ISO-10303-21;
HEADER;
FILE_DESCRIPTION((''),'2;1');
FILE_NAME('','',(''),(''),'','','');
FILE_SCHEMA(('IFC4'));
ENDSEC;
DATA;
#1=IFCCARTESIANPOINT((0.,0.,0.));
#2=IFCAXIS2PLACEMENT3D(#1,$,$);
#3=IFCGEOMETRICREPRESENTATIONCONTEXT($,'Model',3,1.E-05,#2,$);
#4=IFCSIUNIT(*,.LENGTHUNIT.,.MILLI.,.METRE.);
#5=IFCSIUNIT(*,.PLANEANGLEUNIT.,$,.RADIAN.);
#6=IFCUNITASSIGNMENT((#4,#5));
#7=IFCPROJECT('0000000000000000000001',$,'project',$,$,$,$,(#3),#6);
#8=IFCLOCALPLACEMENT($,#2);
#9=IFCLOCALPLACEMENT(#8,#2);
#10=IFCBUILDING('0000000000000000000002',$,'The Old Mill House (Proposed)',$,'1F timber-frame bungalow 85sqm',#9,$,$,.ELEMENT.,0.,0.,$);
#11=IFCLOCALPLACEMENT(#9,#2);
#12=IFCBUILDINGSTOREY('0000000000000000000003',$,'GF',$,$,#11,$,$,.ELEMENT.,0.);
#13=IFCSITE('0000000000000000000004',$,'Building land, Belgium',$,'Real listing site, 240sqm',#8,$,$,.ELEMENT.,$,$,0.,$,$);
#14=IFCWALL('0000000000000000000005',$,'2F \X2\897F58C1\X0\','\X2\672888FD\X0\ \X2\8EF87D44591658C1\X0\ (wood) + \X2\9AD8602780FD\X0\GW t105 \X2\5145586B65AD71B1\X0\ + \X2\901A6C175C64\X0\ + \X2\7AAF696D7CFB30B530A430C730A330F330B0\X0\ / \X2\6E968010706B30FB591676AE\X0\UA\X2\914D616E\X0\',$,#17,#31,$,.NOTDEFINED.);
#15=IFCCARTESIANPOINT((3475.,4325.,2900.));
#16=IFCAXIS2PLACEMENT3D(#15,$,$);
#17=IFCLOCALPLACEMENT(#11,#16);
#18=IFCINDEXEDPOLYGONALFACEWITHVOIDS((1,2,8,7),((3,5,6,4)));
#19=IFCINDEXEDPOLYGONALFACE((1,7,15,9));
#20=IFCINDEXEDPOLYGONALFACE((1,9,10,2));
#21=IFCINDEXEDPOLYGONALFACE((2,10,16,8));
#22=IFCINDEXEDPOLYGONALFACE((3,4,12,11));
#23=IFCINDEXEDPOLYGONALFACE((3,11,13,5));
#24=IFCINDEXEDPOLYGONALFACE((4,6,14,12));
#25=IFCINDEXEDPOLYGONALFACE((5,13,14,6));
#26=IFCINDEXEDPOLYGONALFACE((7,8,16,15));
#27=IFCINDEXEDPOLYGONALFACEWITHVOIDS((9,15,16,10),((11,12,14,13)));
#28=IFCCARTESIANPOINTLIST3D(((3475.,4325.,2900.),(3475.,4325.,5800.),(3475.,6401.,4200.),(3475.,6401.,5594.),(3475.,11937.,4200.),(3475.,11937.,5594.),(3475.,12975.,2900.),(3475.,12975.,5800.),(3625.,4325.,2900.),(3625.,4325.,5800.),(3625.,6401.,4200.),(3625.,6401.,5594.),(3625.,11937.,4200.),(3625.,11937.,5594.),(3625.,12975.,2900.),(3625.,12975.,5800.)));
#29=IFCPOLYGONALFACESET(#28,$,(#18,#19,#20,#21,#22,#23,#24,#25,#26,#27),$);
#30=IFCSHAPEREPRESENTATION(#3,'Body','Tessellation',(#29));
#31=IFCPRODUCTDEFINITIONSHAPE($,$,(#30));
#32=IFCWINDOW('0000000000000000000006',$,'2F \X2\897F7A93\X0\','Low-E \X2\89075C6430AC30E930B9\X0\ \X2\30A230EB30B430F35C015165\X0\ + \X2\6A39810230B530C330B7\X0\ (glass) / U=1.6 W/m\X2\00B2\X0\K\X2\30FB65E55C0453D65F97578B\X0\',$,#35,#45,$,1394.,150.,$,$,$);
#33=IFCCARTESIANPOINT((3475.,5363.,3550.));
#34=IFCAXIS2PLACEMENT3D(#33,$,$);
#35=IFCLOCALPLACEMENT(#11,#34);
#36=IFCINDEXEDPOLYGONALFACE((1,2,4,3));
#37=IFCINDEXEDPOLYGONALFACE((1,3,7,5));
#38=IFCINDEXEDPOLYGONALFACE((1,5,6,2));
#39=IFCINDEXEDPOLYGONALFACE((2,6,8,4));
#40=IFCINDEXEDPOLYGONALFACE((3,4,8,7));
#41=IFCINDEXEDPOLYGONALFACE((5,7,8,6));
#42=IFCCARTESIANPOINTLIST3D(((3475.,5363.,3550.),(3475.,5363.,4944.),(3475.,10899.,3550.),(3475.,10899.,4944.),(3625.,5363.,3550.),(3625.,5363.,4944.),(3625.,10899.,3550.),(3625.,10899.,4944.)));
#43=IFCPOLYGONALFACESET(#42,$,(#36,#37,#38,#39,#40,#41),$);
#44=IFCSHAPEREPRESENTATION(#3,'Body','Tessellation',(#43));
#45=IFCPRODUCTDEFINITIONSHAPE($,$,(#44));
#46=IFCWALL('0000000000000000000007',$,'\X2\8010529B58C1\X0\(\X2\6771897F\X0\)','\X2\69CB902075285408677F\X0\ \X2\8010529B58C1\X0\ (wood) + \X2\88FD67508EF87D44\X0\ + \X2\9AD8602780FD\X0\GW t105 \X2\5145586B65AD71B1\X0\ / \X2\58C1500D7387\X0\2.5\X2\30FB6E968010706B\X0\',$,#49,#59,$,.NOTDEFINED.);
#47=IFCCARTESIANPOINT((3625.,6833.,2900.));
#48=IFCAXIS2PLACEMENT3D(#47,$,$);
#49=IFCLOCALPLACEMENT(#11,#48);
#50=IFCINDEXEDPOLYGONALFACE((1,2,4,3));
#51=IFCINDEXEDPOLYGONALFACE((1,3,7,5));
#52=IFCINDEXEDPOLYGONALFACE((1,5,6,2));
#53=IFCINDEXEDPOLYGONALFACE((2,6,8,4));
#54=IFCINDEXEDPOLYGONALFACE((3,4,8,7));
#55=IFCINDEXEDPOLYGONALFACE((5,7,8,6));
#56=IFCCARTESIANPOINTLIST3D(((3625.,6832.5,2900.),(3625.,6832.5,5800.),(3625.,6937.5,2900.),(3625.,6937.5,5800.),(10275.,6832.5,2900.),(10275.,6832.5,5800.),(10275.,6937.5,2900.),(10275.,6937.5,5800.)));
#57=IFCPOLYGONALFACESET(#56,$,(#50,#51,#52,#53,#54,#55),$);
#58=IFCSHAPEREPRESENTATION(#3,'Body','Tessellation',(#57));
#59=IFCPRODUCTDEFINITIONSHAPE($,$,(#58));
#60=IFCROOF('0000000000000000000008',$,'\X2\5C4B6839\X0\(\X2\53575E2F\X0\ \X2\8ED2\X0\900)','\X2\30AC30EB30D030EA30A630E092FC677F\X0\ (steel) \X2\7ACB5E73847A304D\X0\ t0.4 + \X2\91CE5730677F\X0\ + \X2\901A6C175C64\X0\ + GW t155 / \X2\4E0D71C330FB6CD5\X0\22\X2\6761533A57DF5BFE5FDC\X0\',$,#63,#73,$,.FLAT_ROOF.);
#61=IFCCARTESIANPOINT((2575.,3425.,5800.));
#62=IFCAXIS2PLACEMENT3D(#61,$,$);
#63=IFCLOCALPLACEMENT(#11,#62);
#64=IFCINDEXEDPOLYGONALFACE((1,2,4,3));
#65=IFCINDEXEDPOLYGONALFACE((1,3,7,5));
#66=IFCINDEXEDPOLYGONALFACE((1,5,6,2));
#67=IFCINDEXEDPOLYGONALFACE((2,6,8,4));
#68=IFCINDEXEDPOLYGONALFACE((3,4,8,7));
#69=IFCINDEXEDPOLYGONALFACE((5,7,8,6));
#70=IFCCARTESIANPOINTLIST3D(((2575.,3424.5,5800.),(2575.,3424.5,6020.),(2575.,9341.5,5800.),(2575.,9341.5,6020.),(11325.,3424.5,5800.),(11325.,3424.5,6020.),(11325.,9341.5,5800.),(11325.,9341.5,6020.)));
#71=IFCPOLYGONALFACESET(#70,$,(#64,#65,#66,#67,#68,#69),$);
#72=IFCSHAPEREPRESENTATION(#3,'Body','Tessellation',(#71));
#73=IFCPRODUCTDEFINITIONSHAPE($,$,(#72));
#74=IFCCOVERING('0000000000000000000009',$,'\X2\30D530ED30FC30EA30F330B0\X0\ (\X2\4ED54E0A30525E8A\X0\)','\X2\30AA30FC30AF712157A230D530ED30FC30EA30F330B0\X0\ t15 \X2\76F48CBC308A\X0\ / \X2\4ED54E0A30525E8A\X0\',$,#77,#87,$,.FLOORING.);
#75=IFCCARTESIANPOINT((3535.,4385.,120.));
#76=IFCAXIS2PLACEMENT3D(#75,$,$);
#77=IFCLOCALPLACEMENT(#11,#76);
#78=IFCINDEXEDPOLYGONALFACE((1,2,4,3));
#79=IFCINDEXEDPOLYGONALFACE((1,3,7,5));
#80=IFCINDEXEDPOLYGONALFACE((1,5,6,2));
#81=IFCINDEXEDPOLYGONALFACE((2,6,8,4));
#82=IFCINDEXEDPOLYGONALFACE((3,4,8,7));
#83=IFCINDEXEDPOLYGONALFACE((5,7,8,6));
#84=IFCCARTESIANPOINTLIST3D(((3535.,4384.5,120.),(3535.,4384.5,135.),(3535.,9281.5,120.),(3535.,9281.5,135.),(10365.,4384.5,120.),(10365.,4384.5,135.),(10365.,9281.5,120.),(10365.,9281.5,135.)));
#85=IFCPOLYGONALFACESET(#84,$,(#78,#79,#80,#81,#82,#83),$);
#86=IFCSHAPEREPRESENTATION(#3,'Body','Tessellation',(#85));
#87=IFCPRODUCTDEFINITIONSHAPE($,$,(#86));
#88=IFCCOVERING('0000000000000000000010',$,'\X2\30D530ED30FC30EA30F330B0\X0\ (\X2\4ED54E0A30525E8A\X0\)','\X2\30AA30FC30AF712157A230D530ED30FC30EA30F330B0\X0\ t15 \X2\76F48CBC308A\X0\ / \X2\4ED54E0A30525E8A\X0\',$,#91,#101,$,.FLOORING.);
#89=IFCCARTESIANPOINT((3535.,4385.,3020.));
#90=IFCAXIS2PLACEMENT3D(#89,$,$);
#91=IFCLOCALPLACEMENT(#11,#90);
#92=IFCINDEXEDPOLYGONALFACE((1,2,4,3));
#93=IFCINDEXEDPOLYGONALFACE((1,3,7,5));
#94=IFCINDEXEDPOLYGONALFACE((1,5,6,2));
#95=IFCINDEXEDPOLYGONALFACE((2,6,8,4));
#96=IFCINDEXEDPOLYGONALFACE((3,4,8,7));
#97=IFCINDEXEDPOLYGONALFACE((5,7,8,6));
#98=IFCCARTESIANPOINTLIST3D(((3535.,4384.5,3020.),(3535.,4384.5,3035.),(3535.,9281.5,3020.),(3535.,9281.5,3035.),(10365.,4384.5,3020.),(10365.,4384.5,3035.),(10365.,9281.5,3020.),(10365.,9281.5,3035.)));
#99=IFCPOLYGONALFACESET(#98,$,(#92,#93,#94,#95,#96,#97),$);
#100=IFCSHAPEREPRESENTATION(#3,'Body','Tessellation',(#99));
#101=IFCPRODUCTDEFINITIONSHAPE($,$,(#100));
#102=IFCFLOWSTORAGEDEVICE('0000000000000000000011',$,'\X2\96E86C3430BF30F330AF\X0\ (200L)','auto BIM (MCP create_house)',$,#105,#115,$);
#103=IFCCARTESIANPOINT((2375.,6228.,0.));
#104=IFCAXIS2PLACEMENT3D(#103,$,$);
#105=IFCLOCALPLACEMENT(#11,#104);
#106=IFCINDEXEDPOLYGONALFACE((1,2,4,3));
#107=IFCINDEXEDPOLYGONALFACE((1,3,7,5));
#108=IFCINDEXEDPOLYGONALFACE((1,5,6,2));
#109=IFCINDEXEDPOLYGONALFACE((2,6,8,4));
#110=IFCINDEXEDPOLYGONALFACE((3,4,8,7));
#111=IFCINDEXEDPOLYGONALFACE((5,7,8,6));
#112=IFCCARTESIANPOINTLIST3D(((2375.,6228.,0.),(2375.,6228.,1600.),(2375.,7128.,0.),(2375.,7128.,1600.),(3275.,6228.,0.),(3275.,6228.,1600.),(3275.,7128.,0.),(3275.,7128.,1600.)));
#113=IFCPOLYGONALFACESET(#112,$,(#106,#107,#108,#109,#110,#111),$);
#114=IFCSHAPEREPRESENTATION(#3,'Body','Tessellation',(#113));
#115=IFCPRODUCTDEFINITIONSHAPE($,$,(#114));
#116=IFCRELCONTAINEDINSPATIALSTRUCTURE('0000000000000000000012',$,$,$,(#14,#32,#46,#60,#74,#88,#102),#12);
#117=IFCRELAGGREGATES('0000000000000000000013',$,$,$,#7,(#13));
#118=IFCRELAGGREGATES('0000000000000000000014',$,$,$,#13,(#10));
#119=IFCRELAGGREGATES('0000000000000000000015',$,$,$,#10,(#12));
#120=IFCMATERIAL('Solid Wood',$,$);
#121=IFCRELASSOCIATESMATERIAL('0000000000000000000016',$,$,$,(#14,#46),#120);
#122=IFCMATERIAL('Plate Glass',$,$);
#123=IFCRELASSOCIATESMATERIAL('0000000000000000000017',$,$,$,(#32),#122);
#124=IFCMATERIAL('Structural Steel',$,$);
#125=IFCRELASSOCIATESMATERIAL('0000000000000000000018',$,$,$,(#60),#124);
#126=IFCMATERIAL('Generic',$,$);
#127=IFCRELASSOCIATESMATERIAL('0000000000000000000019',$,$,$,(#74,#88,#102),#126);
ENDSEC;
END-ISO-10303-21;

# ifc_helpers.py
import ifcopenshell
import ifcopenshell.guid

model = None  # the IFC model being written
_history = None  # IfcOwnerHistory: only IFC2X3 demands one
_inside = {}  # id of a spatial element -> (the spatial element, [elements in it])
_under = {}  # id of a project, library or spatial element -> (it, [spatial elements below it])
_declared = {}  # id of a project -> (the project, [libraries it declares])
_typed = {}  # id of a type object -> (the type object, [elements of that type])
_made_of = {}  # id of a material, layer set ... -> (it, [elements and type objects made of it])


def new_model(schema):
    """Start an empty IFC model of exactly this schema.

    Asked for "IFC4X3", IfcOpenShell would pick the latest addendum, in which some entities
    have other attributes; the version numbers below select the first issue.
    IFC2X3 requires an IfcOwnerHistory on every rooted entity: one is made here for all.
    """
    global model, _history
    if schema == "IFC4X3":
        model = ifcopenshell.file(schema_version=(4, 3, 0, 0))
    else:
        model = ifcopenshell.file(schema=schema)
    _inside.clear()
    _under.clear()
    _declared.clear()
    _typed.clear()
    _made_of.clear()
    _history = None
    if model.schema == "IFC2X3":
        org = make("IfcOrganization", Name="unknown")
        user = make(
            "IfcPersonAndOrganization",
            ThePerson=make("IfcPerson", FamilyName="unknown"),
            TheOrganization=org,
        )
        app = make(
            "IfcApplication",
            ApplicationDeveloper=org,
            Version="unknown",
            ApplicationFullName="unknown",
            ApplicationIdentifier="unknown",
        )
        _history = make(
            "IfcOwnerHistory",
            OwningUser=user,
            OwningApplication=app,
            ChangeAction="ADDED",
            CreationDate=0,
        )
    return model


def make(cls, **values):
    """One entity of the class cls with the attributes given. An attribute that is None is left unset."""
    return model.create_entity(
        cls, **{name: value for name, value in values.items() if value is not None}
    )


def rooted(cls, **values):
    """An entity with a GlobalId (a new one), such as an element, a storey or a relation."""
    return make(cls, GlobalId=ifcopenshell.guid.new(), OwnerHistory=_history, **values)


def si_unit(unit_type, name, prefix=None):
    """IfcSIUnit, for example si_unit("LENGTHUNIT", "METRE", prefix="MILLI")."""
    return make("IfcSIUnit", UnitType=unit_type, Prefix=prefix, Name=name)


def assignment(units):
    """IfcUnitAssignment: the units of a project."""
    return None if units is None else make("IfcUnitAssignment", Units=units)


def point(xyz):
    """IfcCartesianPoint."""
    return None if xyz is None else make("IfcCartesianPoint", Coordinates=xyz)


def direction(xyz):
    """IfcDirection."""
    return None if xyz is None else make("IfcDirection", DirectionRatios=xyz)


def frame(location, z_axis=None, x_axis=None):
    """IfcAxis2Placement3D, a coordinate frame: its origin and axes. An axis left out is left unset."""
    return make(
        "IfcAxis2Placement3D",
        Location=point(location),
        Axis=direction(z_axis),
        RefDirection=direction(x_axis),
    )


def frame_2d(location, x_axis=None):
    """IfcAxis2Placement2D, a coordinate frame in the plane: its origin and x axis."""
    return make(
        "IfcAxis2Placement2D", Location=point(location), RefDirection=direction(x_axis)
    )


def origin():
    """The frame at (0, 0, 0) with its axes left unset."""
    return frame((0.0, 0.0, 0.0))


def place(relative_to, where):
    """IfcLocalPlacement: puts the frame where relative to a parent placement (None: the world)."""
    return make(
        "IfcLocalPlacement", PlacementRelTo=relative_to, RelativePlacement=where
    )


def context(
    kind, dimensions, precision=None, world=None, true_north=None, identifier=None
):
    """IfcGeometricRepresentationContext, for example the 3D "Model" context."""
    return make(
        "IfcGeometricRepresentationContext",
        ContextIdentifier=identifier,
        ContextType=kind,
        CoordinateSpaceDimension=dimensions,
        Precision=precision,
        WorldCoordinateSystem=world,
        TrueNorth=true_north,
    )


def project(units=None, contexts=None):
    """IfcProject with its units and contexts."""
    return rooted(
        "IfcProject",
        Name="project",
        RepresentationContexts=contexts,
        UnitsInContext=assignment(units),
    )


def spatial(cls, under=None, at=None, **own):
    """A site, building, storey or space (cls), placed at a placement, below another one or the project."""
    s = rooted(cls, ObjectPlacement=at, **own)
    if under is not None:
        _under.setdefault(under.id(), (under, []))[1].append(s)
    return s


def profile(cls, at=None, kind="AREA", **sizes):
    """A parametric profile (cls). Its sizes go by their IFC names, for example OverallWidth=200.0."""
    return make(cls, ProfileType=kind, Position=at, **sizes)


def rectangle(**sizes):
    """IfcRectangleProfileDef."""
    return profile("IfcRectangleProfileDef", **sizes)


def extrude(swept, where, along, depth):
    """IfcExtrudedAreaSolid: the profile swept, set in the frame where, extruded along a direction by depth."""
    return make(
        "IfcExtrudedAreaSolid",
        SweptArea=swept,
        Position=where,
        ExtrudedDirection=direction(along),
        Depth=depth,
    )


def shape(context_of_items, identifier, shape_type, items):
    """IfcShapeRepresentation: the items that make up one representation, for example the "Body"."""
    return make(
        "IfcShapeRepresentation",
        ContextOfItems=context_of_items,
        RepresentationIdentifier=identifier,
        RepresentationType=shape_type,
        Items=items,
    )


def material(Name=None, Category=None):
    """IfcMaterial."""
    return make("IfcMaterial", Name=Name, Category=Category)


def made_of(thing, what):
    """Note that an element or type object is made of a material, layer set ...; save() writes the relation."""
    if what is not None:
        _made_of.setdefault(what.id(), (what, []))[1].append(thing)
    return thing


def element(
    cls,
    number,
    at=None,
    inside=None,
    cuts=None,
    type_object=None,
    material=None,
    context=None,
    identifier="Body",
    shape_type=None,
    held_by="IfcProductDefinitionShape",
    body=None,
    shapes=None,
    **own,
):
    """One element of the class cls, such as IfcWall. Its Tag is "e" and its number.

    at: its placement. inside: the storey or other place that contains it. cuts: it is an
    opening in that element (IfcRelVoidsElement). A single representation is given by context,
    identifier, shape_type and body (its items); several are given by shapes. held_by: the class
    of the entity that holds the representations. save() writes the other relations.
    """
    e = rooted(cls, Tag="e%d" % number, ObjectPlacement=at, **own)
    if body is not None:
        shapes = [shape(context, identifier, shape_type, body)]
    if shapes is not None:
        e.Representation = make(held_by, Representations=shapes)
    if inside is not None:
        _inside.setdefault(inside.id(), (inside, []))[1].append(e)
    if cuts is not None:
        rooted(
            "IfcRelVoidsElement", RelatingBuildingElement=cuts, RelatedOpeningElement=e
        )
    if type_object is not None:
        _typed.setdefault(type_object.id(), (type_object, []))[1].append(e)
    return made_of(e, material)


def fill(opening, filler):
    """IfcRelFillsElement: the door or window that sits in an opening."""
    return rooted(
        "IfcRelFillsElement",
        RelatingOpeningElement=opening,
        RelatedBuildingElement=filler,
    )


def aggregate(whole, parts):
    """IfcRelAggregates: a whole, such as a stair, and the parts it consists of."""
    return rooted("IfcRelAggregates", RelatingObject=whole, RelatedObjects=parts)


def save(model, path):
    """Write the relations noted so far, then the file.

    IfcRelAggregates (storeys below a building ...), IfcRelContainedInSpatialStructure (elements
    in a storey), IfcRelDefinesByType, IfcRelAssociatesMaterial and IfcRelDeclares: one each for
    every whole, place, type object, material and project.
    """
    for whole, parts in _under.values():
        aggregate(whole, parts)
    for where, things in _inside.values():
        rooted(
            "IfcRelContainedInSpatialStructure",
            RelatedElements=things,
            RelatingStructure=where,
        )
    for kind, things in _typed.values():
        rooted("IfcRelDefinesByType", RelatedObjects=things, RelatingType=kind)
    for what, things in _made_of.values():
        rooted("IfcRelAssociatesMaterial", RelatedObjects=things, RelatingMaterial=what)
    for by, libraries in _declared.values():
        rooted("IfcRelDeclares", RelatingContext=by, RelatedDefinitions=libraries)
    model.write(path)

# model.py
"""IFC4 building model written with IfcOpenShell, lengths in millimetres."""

from ifc_helpers import new_model, si_unit, frame, frame_2d, origin, place, context, project, spatial, rectangle, extrude, material, element, fill, save


model = new_model("IFC4")

# Units and contexts
model_context = context("Model", 3, precision=1e-05, world=origin())
ifc_project = project(units=[si_unit("LENGTHUNIT", "METRE", prefix="MILLI"), si_unit("PLANEANGLEUNIT", "RADIAN")], contexts=[model_context])

# Site, building, storey
site_placement = place(None, origin())
site = spatial("IfcSite", under=ifc_project, at=site_placement, Name="Building land, Belgium", ObjectType="Real listing site, 240sqm", CompositionType="ELEMENT", RefElevation=0.0)
building_placement = place(site_placement, origin())
building = spatial("IfcBuilding", under=site, at=building_placement, Name="The Old Mill House (Proposed)", ObjectType="1F timber-frame bungalow 85sqm", CompositionType="ELEMENT", ElevationOfRefHeight=0.0, ElevationOfTerrain=0.0)
storey_placement = place(building_placement, origin())
storey = spatial("IfcBuildingStorey", under=building, at=storey_placement, Name="GF", CompositionType="ELEMENT", Elevation=0.0)

# Shared definitions
ifc_material_1 = material(Name="Solid Wood")
ifc_material_2 = material(Name="Generic")

# Shared definitions
ifc_material_3 = material(Name="Plate Glass")

# Wall, opening, window
wall_1_placement = place(storey_placement, frame((3475.0, 4325.0, 2900.0)))
wall_1 = element("IfcWall", 1, at=wall_1_placement, inside=storey, material=ifc_material_1, Name="2F 西壁", Description="木製 軸組外壁 (wood) + 高性能GW t105 充填断熱 + 通気層 + 窯業系サイディング / 準耐火・外皮UA配慮", PredefinedType="NOTDEFINED", context=model_context, shape_type="SweptSolid", body=[
    extrude(rectangle(XDim=150.0, YDim=8650.0, at=frame_2d((75.0, 4325.0))), frame((3475.0, 4325.0, 2900.0)), (0.0, 0.0, 1.0), 2900.0),
])
opening_1_placement = place(storey_placement, frame((3475.0, 5363.0, 3550.0)))
opening_1 = element("IfcOpeningElement", 2, at=opening_1_placement, cuts=wall_1, PredefinedType="NOTDEFINED", context=model_context, shape_type="SweptSolid", body=[
    extrude(rectangle(XDim=150.0, YDim=5536.0, at=frame_2d((75.0, 2768.0))), frame((3475.0, 5363.0, 3550.0)), (0.0, 0.0, 1.0), 1394.0),
])
window_1_placement = place(storey_placement, frame((3475.0, 5363.0, 3550.0)))
window_1 = element("IfcWindow", 3, at=window_1_placement, inside=storey, material=ifc_material_3, Name="2F 西窓", Description="Low-E 複層ガラス アルゴン封入 + 樹脂サッシ (glass) / U=1.6 W/m²K・日射取得型", OverallHeight=1394.0, OverallWidth=150.0, context=model_context, shape_type="SweptSolid", body=[
    extrude(rectangle(XDim=150.0, YDim=5536.0, at=frame_2d((75.0, 2768.0))), frame((3475.0, 5363.0, 3550.0)), (0.0, 0.0, 1.0), 1394.0),
])
fill(opening_1, window_1)

# Wall
wall_2_placement = place(storey_placement, frame((3625.0, 6833.0, 2900.0)))
element("IfcWall", 4, at=wall_2_placement, inside=storey, material=ifc_material_1, Name="耐力壁(東西)", Description="構造用合板 耐力壁 (wood) + 製材軸組 + 高性能GW t105 充填断熱 / 壁倍率2.5・準耐火", PredefinedType="NOTDEFINED", context=model_context, shape_type="SweptSolid", body=[
    extrude(rectangle(XDim=6650.0, YDim=105.0, at=frame_2d((3325.0, 52.0))), frame((3625.0, 6833.0, 2900.0)), (0.0, 0.0, 1.0), 2900.0),
])

# Roof
ifc_material_4 = material(Name="Structural Steel")
for number, where, name in (
    (5, (2575.0, 3425.0, 5800.0), "屋根(南帯 軒900)"),
):
    element("IfcRoof", number, at=place(storey_placement, frame(where)), inside=storey, material=ifc_material_4, Name=name, Description="ガルバリウム鋼板 (steel) 立平葺き t0.4 + 野地板 + 通気層 + GW t155 / 不燃・法22条区域対応", PredefinedType="FLAT_ROOF", context=model_context, shape_type="SweptSolid", body=[
        extrude(rectangle(XDim=8750.0, YDim=5917.0, at=frame_2d((4375.0, 2958.0))), frame((2575.0, 3425.0, 5800.0)), (0.0, 0.0, 1.0), 220.0),
    ])

# Coverings
covering_1_placement = place(storey_placement, frame((3535.0, 4385.0, 120.0)))
element("IfcCovering", 6, at=covering_1_placement, inside=storey, material=ifc_material_2, Name="フローリング (仕上げ床)", Description="オーク無垢フローリング t15 直貼り / 仕上げ床", PredefinedType="FLOORING", context=model_context, shape_type="SweptSolid", body=[
    extrude(rectangle(XDim=6830.0, YDim=4897.0, at=frame_2d((3415.0, 2448.0))), frame((3535.0, 4385.0, 120.0)), (0.0, 0.0, 1.0), 15.0),
])
covering_2_placement = place(storey_placement, frame((3535.0, 4385.0, 3020.0)))
element("IfcCovering", 7, at=covering_2_placement, inside=storey, material=ifc_material_2, Name="フローリング (仕上げ床)", Description="オーク無垢フローリング t15 直貼り / 仕上げ床", PredefinedType="FLOORING", context=model_context, shape_type="SweptSolid", body=[
    extrude(rectangle(XDim=6830.0, YDim=4897.0, at=frame_2d((3415.0, 2448.0))), frame((3535.0, 4385.0, 3020.0)), (0.0, 0.0, 1.0), 15.0),
])

# Flow storage device
flow_storage_device_placement = place(storey_placement, frame((2375.0, 6228.0, 0.0)))
element("IfcFlowStorageDevice", 8, at=flow_storage_device_placement, inside=storey, material=ifc_material_2, Name="雨水タンク (200L)", Description="auto BIM (MCP create_house)", context=model_context, shape_type="SweptSolid", body=[
    extrude(rectangle(XDim=900.0, YDim=900.0, at=frame_2d((450.0, 450.0))), frame((2375.0, 6228.0, 0.0)), (0.0, 0.0, 1.0), 1600.0),
])

save(model, "model.ifc")
